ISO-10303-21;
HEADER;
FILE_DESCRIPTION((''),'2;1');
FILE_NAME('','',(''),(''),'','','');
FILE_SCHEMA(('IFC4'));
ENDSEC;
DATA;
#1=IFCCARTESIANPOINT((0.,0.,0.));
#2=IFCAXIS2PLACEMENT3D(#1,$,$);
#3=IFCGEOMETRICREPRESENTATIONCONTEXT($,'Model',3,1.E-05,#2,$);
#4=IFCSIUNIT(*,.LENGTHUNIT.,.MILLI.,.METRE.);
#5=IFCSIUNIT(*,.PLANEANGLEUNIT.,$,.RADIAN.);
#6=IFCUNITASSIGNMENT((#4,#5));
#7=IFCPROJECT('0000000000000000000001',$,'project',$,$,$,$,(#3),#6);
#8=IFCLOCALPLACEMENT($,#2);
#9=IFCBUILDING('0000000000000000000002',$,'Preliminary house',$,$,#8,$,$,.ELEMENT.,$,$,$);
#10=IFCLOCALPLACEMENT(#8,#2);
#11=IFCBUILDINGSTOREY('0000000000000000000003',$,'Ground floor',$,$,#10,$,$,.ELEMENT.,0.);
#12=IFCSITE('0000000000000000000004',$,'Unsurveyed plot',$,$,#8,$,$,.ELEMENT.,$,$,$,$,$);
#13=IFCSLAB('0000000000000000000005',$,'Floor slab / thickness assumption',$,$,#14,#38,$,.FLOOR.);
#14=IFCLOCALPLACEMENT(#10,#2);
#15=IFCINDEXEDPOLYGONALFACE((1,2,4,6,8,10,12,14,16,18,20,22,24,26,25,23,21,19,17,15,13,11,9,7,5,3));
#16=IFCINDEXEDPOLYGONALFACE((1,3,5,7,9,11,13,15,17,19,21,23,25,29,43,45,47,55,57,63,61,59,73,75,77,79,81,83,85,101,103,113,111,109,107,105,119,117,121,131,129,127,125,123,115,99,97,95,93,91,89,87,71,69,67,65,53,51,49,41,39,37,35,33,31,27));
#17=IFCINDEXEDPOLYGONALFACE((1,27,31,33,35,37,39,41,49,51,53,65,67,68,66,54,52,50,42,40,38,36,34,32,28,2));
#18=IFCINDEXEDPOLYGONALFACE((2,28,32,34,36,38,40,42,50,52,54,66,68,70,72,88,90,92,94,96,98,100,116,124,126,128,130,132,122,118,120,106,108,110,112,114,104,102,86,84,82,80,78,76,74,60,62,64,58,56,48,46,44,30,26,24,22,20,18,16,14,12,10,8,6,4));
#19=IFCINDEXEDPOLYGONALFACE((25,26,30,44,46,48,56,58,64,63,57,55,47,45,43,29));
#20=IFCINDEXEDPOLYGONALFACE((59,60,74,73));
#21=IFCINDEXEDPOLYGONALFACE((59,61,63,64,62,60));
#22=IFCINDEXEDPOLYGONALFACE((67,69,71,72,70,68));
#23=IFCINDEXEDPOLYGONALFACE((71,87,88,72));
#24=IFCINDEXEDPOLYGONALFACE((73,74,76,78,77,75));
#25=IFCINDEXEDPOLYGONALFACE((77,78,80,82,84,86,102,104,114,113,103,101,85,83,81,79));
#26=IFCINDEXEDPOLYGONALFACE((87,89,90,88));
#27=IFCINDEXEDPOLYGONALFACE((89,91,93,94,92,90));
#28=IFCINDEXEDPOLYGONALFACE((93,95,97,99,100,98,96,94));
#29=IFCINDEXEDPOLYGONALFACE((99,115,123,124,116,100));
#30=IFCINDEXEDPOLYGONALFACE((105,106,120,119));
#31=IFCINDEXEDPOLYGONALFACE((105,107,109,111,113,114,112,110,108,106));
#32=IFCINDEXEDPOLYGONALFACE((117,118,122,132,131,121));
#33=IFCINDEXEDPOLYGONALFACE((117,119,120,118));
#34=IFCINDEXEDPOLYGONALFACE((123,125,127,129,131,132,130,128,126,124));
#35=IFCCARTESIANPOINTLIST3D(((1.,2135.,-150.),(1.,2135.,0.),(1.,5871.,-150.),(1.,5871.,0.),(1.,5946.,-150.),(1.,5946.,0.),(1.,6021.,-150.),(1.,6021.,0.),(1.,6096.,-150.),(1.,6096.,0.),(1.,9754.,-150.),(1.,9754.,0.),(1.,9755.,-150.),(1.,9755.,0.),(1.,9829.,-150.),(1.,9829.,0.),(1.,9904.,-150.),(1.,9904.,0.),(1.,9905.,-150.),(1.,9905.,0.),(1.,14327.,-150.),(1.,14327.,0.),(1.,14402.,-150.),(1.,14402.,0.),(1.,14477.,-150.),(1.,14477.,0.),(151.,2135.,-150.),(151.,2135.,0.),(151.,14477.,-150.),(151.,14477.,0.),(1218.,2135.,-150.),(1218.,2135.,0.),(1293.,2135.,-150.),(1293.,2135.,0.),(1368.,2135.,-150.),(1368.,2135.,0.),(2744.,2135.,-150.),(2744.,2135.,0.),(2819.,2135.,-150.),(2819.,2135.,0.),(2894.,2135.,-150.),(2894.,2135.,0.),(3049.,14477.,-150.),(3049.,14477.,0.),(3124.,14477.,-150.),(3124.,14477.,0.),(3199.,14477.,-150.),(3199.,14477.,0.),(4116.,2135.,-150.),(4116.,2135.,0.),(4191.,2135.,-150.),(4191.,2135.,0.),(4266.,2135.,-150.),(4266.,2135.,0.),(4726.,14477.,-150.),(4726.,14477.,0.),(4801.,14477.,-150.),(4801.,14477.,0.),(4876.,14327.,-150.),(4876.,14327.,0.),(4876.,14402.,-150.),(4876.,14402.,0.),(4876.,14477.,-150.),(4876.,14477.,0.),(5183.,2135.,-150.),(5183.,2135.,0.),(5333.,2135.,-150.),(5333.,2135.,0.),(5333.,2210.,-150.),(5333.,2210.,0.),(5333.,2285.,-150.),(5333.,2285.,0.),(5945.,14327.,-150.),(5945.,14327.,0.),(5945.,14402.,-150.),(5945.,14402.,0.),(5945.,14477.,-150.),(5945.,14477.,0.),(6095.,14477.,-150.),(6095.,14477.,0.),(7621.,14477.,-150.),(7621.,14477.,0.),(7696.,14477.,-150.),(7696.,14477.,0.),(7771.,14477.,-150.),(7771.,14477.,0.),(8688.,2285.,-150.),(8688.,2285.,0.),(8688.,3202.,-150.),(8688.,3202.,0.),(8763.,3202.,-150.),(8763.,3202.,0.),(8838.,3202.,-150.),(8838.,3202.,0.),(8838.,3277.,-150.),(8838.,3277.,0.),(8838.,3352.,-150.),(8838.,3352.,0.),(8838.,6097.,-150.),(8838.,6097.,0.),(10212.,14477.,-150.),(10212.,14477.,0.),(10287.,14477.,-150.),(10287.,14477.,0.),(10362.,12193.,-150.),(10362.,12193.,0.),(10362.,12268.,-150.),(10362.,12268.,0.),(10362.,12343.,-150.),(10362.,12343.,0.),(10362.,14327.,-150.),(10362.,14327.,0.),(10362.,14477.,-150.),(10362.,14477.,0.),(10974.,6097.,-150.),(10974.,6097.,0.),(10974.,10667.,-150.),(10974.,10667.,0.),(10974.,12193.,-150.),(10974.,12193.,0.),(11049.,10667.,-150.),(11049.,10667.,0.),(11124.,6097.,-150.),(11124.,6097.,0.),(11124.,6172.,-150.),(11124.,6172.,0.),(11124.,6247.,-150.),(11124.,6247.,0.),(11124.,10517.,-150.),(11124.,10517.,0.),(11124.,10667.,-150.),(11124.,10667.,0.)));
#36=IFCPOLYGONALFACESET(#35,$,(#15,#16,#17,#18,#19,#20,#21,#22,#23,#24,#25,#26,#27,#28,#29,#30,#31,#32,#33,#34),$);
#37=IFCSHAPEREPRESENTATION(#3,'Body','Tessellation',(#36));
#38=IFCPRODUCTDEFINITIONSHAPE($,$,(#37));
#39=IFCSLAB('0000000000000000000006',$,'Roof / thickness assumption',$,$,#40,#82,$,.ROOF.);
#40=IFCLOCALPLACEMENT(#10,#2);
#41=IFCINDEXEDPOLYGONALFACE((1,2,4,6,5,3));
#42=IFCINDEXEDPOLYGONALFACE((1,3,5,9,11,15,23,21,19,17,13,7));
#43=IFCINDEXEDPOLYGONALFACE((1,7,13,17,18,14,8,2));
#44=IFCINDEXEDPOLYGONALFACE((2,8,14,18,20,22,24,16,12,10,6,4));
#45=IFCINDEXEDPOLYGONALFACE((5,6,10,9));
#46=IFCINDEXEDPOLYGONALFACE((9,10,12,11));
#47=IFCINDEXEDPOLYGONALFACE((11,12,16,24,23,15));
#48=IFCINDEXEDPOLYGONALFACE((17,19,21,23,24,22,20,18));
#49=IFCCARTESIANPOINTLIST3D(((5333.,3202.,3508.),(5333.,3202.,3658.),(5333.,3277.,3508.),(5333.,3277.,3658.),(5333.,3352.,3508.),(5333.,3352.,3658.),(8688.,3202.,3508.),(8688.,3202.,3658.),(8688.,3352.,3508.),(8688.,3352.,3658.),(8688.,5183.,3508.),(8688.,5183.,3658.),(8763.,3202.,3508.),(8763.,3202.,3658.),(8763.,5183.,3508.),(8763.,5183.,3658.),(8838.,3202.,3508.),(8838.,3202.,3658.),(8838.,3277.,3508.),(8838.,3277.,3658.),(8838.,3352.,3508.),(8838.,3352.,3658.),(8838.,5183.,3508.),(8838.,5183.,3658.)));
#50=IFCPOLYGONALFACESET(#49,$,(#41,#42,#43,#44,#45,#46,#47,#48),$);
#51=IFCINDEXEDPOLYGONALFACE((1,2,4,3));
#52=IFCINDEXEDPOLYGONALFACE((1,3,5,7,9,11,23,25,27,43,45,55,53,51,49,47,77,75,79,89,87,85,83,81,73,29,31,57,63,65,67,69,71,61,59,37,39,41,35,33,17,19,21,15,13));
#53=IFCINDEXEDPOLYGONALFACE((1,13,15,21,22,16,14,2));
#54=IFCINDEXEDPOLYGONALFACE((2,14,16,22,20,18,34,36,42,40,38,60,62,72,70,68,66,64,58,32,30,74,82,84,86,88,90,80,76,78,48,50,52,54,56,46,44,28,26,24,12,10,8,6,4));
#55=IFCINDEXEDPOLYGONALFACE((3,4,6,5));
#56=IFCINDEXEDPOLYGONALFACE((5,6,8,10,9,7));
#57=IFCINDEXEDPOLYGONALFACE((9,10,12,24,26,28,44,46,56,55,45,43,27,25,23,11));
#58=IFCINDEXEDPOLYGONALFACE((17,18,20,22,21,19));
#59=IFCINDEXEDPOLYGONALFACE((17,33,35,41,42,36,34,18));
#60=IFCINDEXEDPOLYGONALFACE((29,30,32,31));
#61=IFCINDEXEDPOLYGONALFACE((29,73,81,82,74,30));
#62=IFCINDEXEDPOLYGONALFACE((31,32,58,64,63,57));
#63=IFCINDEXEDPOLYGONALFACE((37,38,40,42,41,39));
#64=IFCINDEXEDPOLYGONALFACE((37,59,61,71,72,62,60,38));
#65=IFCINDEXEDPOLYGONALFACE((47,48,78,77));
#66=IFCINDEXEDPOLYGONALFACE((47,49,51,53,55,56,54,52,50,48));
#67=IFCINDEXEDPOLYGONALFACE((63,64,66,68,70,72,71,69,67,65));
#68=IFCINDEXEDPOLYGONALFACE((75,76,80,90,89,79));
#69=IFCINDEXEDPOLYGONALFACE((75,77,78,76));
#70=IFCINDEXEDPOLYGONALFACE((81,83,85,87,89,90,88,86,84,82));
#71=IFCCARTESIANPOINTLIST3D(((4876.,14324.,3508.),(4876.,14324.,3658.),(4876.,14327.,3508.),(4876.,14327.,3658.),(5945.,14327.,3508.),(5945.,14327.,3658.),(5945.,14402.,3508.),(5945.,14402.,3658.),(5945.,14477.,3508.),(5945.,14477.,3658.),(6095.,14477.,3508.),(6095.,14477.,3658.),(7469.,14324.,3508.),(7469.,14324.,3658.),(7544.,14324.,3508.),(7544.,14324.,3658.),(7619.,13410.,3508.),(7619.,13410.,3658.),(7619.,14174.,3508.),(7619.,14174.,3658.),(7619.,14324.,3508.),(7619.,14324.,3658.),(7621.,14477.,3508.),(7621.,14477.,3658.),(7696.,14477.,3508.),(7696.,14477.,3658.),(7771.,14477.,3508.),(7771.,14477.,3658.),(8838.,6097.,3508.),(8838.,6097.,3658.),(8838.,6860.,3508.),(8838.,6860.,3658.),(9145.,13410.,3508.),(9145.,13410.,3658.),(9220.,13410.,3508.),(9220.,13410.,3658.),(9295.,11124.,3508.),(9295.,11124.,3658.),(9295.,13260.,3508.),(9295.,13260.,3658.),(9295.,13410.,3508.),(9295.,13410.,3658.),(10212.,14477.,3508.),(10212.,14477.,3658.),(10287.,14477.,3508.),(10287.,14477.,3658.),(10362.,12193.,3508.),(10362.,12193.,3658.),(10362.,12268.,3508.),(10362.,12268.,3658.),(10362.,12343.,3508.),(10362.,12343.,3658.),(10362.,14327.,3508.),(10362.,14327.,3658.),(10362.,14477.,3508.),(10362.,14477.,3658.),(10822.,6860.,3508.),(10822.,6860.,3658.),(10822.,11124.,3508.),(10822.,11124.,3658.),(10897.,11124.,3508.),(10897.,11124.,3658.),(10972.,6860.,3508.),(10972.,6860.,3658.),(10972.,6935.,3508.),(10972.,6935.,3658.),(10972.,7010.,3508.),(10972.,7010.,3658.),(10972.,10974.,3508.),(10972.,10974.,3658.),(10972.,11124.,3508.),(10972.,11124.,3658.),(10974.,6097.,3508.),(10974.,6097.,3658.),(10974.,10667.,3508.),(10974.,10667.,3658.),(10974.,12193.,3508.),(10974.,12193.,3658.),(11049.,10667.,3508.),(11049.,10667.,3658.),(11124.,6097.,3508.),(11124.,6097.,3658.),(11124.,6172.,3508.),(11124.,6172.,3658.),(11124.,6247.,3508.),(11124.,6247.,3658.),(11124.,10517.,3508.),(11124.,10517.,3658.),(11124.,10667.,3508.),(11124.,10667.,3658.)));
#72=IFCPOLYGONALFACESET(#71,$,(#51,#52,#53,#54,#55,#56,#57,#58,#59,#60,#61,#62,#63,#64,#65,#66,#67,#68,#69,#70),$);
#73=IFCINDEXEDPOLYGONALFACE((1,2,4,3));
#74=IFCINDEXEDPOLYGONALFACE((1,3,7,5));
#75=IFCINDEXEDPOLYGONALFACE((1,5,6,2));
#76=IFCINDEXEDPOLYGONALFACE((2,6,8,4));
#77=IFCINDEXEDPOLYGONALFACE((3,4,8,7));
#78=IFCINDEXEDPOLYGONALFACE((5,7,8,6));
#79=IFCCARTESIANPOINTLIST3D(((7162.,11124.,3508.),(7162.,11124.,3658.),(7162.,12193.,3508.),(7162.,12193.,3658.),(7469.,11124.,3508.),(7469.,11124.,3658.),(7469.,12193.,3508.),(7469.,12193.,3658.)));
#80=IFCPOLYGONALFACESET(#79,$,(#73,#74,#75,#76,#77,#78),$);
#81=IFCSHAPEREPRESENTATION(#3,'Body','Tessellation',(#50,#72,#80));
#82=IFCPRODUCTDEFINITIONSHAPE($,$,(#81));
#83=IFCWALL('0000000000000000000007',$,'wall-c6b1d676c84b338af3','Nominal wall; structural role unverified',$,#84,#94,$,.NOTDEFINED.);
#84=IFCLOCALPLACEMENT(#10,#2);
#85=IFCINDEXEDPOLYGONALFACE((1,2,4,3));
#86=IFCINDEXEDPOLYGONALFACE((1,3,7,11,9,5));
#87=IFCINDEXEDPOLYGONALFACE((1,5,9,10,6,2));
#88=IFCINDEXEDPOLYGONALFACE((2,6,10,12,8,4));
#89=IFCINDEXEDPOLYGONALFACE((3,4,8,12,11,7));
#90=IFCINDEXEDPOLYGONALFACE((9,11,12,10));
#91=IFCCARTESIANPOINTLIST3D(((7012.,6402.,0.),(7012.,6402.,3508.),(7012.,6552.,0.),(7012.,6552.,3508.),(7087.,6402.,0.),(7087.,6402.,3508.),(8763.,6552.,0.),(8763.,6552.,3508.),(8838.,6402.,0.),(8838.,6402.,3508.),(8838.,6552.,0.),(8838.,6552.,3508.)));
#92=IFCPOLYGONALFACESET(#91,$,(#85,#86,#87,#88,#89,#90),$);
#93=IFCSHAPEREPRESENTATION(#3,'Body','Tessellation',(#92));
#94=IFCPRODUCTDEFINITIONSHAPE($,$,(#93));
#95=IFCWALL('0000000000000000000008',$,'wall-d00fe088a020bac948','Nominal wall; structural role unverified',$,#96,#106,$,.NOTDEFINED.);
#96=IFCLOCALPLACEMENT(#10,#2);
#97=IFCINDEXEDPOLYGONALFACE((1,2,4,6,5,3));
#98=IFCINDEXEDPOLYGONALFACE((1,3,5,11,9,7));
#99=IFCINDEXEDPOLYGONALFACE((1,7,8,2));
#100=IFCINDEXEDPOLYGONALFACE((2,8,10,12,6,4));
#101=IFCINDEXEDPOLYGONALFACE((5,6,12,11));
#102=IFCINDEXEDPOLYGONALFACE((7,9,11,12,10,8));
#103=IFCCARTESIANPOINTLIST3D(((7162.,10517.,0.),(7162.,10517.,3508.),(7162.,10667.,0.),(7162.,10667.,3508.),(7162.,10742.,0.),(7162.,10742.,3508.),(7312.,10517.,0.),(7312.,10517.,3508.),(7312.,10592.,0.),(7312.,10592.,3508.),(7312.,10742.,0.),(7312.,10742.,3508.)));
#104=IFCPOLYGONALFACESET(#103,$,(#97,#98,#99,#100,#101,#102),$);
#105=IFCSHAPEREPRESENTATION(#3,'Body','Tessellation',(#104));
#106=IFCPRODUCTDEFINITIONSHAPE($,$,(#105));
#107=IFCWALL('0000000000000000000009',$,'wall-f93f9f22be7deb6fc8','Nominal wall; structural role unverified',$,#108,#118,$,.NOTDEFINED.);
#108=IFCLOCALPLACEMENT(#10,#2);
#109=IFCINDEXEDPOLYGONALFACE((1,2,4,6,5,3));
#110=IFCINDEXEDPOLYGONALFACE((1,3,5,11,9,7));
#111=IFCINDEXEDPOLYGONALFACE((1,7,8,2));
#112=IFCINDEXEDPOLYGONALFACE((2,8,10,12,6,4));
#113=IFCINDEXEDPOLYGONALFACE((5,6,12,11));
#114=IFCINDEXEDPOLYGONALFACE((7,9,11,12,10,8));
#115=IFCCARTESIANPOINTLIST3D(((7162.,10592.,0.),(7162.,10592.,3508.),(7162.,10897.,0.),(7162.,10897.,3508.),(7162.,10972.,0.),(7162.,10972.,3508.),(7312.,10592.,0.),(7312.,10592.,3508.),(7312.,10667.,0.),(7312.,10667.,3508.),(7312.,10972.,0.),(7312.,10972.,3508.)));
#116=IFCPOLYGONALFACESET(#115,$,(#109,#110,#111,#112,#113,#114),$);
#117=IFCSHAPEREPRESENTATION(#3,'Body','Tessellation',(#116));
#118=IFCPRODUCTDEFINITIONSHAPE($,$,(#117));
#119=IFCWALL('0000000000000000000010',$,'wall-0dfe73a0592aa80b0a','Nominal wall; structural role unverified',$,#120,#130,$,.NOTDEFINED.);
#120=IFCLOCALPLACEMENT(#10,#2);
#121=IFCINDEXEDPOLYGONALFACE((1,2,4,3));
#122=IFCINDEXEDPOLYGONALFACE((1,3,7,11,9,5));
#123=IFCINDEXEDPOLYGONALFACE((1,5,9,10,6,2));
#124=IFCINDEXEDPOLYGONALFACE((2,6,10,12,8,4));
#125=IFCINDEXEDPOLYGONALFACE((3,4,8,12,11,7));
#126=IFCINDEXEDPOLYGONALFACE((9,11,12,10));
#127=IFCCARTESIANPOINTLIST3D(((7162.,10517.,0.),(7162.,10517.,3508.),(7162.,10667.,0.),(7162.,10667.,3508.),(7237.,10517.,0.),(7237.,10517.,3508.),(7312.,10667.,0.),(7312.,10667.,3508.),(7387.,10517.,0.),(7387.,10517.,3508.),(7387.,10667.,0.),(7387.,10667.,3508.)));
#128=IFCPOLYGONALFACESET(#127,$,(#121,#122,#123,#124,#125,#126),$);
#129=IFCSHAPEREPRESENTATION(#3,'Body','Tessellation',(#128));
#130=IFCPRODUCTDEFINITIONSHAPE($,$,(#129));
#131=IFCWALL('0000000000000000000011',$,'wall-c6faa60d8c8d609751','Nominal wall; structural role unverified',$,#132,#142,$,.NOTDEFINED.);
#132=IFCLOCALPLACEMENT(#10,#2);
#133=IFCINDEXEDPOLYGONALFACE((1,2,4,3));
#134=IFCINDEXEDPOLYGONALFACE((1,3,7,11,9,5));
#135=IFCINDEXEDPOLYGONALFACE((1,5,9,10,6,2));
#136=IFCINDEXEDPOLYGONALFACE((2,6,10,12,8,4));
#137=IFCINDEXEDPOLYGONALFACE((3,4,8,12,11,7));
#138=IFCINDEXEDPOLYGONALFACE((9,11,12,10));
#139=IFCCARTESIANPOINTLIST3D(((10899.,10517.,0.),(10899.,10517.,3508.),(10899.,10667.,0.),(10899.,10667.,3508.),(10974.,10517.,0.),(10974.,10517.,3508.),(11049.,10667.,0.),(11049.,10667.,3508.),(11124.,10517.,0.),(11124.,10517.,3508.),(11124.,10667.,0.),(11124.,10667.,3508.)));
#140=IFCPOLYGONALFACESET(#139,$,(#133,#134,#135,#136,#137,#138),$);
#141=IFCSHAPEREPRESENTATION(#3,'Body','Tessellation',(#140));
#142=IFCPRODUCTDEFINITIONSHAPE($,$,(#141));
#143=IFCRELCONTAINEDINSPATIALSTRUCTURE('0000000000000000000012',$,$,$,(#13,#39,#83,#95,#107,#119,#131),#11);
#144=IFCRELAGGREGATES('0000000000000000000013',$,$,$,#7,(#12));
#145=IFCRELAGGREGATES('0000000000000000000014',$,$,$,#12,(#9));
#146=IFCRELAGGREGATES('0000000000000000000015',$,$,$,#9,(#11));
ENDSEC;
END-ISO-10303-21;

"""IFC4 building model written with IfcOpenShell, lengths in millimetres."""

from ifc_helpers import new_model, si_unit, frame, origin, place, context, project, spatial, polyline, outline, extrude, element, save


model = new_model("IFC4")

# Units and contexts
model_context = context("Model", 3, precision=1e-05, world=origin())
ifc_project = project(units=[si_unit("LENGTHUNIT", "METRE", prefix="MILLI"), si_unit("PLANEANGLEUNIT", "RADIAN")], contexts=[model_context])

# Site, building, storey
placement_1 = place(None, origin())
site = spatial("IfcSite", under=ifc_project, at=placement_1, Name="Unsurveyed plot", CompositionType="ELEMENT")
building = spatial("IfcBuilding", under=site, at=placement_1, Name="Preliminary house", CompositionType="ELEMENT")
placement_2 = place(placement_1, origin())
storey = spatial("IfcBuildingStorey", under=building, at=placement_2, Name="Ground floor", CompositionType="ELEMENT", Elevation=0.0)

# Slabs
element("IfcSlab", 1, at=placement_2, inside=storey, Name="Floor slab / thickness assumption", PredefinedType="FLOOR", context=model_context, shape_type="SweptSolid", body=[
    extrude(outline(polyline([(1368.0, 2135.0), (1293.0, 2135.0), (1218.0, 2135.0), (151.0, 2135.0), (1.0, 2135.0), (1.0, 5871.0), (1.0, 5946.0), (1.0, 6021.0), (1.0, 6096.0), (1.0, 9754.0), (1.0, 9755.0), (1.0, 9829.0), (1.0, 9904.0), (1.0, 9905.0), (1.0, 14327.0), (1.0, 14402.0), (1.0, 14477.0), (151.0, 14477.0), (3049.0, 14477.0), (3124.0, 14477.0), (3199.0, 14477.0), (4726.0, 14477.0), (4801.0, 14477.0), (4876.0, 14477.0), (4876.0, 14402.0), (4876.0, 14327.0), (5945.0, 14327.0), (5945.0, 14402.0), (5945.0, 14477.0), (6095.0, 14477.0), (7621.0, 14477.0), (7696.0, 14477.0), (7771.0, 14477.0), (10212.0, 14477.0), (10287.0, 14477.0), (10362.0, 14477.0), (10362.0, 14327.0), (10362.0, 12343.0), (10362.0, 12268.0), (10362.0, 12193.0), (10974.0, 12193.0), (10974.0, 10667.0), (11049.0, 10667.0), (11124.0, 10667.0), (11124.0, 10517.0), (11124.0, 6247.0), (11124.0, 6172.0), (11124.0, 6097.0), (10974.0, 6097.0), (8838.0, 6097.0), (8838.0, 3352.0), (8838.0, 3277.0), (8838.0, 3202.0), (8763.0, 3202.0), (8688.0, 3202.0), (8688.0, 2285.0), (5333.0, 2285.0), (5333.0, 2210.0), (5333.0, 2135.0), (5183.0, 2135.0), (4266.0, 2135.0), (4191.0, 2135.0), (4116.0, 2135.0), (2894.0, 2135.0), (2819.0, 2135.0), (2744.0, 2135.0), (1368.0, 2135.0)])), frame((0.0, 0.0, -150.0)), (0.0, 0.0, 1.0), 150.0),
])
element("IfcSlab", 2, at=placement_2, inside=storey, Name="Roof / thickness assumption", PredefinedType="ROOF", context=model_context, shape_type="SweptSolid", body=[
    extrude(outline(polyline([(8838.0, 3277.0), (8838.0, 3202.0), (8763.0, 3202.0), (8688.0, 3202.0), (5333.0, 3202.0), (5333.0, 3277.0), (5333.0, 3352.0), (8688.0, 3352.0), (8688.0, 5183.0), (8763.0, 5183.0), (8838.0, 5183.0), (8838.0, 3352.0), (8838.0, 3277.0)])), frame((0.0, 0.0, 3508.0)), (0.0, 0.0, 1.0), 150.0),
    extrude(outline(polyline([(5945.0, 14477.0), (6095.0, 14477.0), (7621.0, 14477.0), (7696.0, 14477.0), (7771.0, 14477.0), (10212.0, 14477.0), (10287.0, 14477.0), (10362.0, 14477.0), (10362.0, 14327.0), (10362.0, 12343.0), (10362.0, 12268.0), (10362.0, 12193.0), (10974.0, 12193.0), (10974.0, 10667.0), (11049.0, 10667.0), (11124.0, 10667.0), (11124.0, 10517.0), (11124.0, 6247.0), (11124.0, 6172.0), (11124.0, 6097.0), (10974.0, 6097.0), (8838.0, 6097.0), (8838.0, 6860.0), (10822.0, 6860.0), (10972.0, 6860.0), (10972.0, 6935.0), (10972.0, 7010.0), (10972.0, 10974.0), (10972.0, 11124.0), (10897.0, 11124.0), (10822.0, 11124.0), (9295.0, 11124.0), (9295.0, 13260.0), (9295.0, 13410.0), (9220.0, 13410.0), (9145.0, 13410.0), (7619.0, 13410.0), (7619.0, 14174.0), (7619.0, 14324.0), (7544.0, 14324.0), (7469.0, 14324.0), (4876.0, 14324.0), (4876.0, 14327.0), (5945.0, 14327.0), (5945.0, 14402.0), (5945.0, 14477.0)])), frame((0.0, 0.0, 3508.0)), (0.0, 0.0, 1.0), 150.0),
    extrude(outline(polyline([(7162.0, 11124.0), (7162.0, 12193.0), (7469.0, 12193.0), (7469.0, 11124.0), (7162.0, 11124.0)])), frame((0.0, 0.0, 3508.0)), (0.0, 0.0, 1.0), 150.0),
])

# Walls
element("IfcWall", 3, at=placement_2, inside=storey, Name="wall-c6b1d676c84b338af3", Description="Nominal wall; structural role unverified", PredefinedType="NOTDEFINED", context=model_context, shape_type="SweptSolid", body=[
    extrude(outline(polyline([(8763.0, 6552.0), (8838.0, 6552.0), (8838.0, 6402.0), (7087.0, 6402.0), (7012.0, 6402.0), (7012.0, 6552.0), (8763.0, 6552.0)])), origin(), (0.0, 0.0, 1.0), 3508.0),
])
element("IfcWall", 4, at=placement_2, inside=storey, Name="wall-d00fe088a020bac948", Description="Nominal wall; structural role unverified", PredefinedType="NOTDEFINED", context=model_context, shape_type="SweptSolid", body=[
    extrude(outline(polyline([(7162.0, 10667.0), (7162.0, 10742.0), (7312.0, 10742.0), (7312.0, 10592.0), (7312.0, 10517.0), (7162.0, 10517.0), (7162.0, 10667.0)])), origin(), (0.0, 0.0, 1.0), 3508.0),
])
element("IfcWall", 5, at=placement_2, inside=storey, Name="wall-f93f9f22be7deb6fc8", Description="Nominal wall; structural role unverified", PredefinedType="NOTDEFINED", context=model_context, shape_type="SweptSolid", body=[
    extrude(outline(polyline([(7162.0, 10897.0), (7162.0, 10972.0), (7312.0, 10972.0), (7312.0, 10667.0), (7312.0, 10592.0), (7162.0, 10592.0), (7162.0, 10897.0)])), origin(), (0.0, 0.0, 1.0), 3508.0),
])
element("IfcWall", 6, at=placement_2, inside=storey, Name="wall-0dfe73a0592aa80b0a", Description="Nominal wall; structural role unverified", PredefinedType="NOTDEFINED", context=model_context, shape_type="SweptSolid", body=[
    extrude(outline(polyline([(7312.0, 10667.0), (7387.0, 10667.0), (7387.0, 10517.0), (7237.0, 10517.0), (7162.0, 10517.0), (7162.0, 10667.0), (7312.0, 10667.0)])), origin(), (0.0, 0.0, 1.0), 3508.0),
])

# Wall
element("IfcWall", 7, at=placement_2, inside=storey, Name="wall-c6faa60d8c8d609751", Description="Nominal wall; structural role unverified", PredefinedType="NOTDEFINED", context=model_context, shape_type="SweptSolid", body=[
    extrude(outline(polyline([(11049.0, 10667.0), (11124.0, 10667.0), (11124.0, 10517.0), (10974.0, 10517.0), (10899.0, 10517.0), (10899.0, 10667.0), (11049.0, 10667.0)])), origin(), (0.0, 0.0, 1.0), 3508.0),
])

save(model, "model.ifc")
